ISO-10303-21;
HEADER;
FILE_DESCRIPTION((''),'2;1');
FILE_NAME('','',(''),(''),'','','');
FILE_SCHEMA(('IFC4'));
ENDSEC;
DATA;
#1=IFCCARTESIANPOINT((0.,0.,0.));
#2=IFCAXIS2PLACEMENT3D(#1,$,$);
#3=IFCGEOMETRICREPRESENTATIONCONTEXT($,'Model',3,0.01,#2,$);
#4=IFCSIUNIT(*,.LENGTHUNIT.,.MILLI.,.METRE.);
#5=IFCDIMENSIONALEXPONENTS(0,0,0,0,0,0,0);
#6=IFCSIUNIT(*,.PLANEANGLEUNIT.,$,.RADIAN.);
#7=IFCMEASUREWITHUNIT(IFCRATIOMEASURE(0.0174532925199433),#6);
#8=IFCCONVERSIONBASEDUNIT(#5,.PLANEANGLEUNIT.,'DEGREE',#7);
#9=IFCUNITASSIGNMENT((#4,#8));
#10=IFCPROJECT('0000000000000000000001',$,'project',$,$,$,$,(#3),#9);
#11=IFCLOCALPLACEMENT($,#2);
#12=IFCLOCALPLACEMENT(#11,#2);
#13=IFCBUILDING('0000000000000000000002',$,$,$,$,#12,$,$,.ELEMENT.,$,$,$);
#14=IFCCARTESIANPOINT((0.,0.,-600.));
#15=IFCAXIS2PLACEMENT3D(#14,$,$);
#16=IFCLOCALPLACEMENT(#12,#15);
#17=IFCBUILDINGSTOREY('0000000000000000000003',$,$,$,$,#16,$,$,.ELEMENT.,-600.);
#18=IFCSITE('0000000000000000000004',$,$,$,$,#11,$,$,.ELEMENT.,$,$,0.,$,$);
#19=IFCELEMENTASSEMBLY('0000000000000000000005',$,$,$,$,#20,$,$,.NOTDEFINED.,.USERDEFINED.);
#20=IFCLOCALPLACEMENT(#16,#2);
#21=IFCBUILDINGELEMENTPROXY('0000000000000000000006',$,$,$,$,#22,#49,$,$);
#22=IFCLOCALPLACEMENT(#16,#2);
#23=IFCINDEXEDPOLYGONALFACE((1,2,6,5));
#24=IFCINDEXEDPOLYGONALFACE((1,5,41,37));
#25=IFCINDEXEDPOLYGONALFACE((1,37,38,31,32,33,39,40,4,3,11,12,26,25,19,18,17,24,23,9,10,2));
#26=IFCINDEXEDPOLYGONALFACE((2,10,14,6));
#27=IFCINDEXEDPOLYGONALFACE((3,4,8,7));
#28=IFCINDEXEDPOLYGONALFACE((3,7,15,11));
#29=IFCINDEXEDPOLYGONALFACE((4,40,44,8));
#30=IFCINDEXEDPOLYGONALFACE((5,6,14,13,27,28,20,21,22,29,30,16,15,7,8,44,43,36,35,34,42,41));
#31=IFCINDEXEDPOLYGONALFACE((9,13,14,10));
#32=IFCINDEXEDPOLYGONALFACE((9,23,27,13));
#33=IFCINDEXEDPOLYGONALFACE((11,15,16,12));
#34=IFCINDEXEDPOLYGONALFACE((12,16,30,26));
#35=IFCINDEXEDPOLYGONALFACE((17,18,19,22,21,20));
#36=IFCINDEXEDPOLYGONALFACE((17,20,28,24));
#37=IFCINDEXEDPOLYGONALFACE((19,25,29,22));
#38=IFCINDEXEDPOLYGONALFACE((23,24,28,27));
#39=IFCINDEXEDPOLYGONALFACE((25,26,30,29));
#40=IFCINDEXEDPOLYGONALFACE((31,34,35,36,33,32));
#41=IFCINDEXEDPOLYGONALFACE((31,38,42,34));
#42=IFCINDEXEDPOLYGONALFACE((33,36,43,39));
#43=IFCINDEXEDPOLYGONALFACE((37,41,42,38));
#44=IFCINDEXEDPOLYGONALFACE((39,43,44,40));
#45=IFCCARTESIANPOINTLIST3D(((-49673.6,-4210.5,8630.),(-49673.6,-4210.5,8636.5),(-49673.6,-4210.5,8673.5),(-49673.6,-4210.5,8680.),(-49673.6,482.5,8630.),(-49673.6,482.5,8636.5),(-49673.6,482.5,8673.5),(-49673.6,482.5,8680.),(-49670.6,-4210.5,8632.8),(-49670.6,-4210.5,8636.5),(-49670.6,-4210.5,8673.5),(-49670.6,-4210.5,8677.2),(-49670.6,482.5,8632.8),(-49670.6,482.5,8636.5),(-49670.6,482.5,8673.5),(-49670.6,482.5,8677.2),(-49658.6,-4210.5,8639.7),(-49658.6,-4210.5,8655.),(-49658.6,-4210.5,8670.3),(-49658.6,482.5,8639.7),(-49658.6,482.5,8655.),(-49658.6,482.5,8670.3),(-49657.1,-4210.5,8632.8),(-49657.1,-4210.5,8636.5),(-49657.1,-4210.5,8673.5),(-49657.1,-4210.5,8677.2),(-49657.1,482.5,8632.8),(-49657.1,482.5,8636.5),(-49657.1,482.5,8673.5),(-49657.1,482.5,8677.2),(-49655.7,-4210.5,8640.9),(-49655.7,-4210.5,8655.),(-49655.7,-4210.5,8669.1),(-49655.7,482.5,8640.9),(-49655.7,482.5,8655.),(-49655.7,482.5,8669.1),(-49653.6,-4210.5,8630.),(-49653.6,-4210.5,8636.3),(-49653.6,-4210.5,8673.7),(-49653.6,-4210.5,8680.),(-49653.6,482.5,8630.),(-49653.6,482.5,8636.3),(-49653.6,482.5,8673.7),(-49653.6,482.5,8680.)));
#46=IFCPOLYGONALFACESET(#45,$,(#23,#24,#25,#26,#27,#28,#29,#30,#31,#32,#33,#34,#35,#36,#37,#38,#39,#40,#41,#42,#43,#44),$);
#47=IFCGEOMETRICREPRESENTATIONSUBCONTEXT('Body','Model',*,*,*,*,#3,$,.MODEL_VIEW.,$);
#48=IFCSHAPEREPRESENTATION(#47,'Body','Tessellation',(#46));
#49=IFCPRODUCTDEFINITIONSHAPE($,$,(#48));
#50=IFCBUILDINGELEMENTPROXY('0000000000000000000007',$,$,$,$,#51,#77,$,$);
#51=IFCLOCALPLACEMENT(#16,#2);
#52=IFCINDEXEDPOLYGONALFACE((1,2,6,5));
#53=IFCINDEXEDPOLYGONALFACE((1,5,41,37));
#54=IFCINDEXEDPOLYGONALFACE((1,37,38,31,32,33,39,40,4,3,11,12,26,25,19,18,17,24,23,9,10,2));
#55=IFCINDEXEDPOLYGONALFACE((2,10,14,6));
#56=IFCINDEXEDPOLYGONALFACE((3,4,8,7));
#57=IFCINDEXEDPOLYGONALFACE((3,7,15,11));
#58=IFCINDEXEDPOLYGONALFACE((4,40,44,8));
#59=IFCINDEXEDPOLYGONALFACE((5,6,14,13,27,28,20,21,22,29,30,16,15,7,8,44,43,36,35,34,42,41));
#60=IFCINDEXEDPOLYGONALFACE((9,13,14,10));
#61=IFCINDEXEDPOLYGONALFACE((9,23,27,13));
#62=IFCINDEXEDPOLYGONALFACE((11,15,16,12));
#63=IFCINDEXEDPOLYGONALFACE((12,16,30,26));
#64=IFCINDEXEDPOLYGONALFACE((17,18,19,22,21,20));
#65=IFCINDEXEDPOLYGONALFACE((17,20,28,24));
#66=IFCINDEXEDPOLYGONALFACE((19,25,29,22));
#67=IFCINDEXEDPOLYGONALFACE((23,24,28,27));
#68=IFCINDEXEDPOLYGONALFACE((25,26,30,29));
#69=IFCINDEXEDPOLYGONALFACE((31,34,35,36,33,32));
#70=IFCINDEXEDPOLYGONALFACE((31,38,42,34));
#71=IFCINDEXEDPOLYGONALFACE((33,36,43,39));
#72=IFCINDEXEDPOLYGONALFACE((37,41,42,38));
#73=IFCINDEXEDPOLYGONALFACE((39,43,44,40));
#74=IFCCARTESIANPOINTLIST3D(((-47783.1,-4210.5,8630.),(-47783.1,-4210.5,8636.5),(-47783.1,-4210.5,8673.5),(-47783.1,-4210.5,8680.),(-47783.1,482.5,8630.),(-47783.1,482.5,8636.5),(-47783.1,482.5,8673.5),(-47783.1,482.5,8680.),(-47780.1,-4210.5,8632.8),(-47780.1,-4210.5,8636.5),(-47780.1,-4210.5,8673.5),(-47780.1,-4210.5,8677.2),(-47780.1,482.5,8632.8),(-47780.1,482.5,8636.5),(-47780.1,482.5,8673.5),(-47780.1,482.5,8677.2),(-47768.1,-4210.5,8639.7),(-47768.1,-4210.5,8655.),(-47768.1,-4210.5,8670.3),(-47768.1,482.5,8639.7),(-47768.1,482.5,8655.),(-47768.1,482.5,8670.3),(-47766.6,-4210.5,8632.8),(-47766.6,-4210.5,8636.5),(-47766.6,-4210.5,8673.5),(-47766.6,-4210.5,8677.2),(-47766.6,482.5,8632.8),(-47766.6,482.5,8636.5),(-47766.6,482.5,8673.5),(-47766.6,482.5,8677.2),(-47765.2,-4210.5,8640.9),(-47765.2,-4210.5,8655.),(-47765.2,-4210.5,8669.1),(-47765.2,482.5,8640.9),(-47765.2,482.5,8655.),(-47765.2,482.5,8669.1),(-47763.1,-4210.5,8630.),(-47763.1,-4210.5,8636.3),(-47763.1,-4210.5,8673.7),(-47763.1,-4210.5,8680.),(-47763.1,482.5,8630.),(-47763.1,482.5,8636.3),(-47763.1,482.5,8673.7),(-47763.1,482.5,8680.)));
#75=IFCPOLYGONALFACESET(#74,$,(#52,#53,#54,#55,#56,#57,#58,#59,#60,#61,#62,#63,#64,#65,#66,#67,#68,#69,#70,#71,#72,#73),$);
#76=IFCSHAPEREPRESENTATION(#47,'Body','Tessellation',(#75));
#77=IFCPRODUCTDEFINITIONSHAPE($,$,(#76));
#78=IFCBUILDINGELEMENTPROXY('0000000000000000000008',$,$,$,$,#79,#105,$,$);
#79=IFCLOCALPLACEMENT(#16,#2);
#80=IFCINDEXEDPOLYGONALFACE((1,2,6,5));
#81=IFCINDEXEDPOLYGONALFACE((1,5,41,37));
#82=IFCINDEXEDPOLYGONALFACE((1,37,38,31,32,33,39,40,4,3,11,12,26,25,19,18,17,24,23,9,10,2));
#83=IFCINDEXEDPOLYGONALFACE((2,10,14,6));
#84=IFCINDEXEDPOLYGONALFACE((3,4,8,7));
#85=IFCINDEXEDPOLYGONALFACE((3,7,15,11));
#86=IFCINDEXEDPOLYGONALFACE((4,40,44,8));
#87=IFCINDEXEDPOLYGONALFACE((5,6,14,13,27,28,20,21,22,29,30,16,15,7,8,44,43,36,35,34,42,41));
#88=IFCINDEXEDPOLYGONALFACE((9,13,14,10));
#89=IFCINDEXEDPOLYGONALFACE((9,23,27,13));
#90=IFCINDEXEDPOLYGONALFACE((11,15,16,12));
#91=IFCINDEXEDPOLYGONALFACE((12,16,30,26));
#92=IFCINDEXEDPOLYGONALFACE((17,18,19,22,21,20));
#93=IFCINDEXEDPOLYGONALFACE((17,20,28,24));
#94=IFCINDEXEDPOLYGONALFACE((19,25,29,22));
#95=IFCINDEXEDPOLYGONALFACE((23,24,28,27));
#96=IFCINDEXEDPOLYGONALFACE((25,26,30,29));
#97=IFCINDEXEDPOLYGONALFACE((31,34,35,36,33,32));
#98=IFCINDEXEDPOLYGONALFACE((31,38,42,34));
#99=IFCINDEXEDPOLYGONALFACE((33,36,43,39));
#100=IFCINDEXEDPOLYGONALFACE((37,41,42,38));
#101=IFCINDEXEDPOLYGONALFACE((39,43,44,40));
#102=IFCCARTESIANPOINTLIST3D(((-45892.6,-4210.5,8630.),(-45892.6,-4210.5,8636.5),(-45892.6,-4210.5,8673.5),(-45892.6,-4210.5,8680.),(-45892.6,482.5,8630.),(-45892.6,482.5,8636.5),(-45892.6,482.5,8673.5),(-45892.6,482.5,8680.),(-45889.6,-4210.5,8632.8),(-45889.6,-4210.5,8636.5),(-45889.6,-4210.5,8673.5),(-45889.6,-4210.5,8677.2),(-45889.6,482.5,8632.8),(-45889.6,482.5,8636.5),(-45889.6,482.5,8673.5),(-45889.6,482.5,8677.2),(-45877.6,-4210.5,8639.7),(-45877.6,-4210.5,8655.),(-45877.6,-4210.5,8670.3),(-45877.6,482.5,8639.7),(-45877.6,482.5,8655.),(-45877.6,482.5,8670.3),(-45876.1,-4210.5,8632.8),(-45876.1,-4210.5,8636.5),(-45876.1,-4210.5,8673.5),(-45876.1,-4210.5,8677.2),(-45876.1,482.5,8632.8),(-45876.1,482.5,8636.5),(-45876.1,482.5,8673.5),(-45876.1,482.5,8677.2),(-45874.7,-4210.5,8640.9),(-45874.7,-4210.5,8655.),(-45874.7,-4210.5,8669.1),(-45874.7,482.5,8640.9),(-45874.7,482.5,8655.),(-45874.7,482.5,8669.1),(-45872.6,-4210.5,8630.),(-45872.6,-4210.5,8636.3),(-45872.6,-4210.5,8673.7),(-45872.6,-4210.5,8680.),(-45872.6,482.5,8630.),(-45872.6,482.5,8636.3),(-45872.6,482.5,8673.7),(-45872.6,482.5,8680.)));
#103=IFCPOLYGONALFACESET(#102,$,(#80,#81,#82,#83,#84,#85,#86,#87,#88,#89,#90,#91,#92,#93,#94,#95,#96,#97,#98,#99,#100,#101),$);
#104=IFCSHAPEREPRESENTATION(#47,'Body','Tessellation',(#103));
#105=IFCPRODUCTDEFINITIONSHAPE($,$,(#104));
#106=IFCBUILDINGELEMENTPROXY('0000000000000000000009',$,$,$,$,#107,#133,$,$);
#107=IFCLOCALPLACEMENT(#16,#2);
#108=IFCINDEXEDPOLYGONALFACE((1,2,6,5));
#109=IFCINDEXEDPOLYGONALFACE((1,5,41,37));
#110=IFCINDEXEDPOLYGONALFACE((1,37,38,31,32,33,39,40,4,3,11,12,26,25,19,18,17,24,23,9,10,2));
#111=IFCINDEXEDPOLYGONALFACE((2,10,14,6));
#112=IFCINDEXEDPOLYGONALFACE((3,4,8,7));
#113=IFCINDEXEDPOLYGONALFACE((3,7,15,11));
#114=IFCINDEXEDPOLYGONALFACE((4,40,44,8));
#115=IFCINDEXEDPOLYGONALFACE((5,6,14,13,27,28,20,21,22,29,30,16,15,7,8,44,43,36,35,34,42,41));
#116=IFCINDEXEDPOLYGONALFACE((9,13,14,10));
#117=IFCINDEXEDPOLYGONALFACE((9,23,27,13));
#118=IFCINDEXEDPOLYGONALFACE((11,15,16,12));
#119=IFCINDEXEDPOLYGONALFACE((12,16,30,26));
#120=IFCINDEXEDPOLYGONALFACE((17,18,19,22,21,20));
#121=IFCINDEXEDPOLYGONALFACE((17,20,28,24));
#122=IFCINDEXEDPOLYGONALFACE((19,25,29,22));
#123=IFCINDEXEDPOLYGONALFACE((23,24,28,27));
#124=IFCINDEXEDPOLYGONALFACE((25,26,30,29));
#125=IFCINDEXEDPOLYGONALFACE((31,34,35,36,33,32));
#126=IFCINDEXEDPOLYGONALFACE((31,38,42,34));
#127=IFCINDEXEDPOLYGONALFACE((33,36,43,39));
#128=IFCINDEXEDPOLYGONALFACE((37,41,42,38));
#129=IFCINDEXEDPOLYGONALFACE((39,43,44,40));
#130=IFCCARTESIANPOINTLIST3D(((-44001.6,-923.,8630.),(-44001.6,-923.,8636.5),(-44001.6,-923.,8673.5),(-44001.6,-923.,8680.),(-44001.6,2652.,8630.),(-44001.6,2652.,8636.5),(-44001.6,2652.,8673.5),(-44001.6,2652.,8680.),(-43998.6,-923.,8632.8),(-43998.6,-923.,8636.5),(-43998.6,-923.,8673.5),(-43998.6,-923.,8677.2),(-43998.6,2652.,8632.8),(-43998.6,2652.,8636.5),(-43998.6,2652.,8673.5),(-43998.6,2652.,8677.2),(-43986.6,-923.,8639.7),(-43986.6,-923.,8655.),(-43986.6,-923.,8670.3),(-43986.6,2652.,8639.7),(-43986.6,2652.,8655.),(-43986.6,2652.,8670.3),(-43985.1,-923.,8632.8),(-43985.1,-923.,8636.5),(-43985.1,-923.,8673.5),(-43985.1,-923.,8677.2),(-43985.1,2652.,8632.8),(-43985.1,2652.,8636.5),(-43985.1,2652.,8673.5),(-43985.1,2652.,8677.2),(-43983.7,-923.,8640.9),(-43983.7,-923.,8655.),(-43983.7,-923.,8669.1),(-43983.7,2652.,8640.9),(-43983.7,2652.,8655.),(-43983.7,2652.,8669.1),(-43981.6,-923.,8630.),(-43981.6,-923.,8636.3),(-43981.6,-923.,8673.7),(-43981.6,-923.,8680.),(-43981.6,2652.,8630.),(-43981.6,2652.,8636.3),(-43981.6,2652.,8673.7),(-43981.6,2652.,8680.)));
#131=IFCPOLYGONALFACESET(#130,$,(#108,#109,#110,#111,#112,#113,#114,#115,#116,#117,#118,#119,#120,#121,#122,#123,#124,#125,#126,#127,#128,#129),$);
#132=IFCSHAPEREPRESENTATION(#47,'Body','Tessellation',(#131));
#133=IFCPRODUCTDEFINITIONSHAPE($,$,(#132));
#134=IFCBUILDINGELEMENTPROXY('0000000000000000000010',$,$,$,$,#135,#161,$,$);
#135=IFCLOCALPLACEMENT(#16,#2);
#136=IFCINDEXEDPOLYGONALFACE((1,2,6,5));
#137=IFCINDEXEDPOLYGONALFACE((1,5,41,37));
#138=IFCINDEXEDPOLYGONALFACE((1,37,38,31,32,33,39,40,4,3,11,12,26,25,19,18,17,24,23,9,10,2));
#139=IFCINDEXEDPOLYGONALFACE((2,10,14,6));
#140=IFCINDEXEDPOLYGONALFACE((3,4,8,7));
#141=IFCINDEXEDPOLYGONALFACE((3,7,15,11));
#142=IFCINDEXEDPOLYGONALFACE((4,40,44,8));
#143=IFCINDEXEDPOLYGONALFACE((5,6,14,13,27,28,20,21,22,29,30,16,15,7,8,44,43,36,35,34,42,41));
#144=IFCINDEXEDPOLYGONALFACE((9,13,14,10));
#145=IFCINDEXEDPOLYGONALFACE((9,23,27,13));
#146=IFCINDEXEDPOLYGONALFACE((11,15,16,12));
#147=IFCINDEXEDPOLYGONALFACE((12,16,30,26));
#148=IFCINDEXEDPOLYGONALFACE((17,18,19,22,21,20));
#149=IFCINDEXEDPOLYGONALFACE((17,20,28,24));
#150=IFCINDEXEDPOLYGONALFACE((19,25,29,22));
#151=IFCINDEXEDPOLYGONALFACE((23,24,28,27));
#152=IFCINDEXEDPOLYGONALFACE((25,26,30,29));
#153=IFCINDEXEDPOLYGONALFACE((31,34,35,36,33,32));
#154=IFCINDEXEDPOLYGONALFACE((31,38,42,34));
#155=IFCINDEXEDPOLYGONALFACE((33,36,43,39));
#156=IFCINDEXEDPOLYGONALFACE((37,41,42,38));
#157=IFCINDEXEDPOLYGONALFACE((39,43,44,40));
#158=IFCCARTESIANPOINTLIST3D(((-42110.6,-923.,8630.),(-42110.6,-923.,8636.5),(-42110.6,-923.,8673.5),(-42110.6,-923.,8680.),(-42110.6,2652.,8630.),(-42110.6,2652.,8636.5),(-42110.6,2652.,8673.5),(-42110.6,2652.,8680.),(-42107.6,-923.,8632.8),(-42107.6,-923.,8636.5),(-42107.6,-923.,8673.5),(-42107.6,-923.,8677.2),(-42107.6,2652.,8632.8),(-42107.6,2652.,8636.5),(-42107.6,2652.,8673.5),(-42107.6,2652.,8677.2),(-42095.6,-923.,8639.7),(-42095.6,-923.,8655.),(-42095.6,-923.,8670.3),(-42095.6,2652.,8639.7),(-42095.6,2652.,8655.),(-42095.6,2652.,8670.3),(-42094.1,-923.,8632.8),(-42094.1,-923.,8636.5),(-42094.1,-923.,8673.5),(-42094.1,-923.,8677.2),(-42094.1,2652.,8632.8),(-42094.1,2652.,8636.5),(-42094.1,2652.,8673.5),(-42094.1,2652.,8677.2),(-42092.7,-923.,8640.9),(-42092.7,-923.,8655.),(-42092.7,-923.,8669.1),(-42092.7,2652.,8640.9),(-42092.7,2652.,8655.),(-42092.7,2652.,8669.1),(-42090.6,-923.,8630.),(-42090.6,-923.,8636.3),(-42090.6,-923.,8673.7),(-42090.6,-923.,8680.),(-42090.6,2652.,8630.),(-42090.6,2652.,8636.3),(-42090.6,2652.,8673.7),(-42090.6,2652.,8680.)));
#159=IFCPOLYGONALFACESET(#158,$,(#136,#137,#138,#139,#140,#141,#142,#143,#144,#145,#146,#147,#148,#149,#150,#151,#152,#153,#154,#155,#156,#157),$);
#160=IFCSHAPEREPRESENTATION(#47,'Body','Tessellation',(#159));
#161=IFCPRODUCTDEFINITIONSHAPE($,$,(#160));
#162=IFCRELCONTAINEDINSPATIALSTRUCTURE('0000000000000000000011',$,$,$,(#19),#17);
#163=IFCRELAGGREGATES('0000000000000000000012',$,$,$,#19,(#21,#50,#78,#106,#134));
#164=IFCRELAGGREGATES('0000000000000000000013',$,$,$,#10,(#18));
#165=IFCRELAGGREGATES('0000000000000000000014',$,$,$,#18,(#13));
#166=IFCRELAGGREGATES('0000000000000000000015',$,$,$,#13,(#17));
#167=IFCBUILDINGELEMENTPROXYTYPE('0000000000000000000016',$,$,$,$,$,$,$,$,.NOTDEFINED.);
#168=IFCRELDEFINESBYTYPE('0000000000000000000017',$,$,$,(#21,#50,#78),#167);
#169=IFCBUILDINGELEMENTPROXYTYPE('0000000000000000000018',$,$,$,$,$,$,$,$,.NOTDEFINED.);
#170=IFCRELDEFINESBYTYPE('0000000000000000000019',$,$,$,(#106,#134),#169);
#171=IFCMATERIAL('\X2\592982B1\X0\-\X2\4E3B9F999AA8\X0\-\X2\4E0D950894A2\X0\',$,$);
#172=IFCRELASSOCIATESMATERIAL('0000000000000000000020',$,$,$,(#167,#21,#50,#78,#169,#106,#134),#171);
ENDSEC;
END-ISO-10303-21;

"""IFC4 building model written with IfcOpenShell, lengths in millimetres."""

from ifc_helpers import new_model, entity, si_unit, converted_unit, frame, origin, place, context, subcontext, project, spatial, polyline, outline, extrude, source, transform, mapped, material, type_object, type_shapes, element, aggregate, save


model = new_model("IFC4")

# Units and contexts
model_context = context("Model", 3, precision=0.01, world=origin())
body_context = subcontext(model_context, "Body", "Model", "MODEL_VIEW")
ifc_project = project(units=[si_unit("LENGTHUNIT", "METRE", prefix="MILLI"), converted_unit("PLANEANGLEUNIT", "DEGREE", entity("IfcRatioMeasure", 0.0174532925199433), si_unit("PLANEANGLEUNIT", "RADIAN"), dimensions=[0, 0, 0, 0, 0, 0, 0])], contexts=[model_context])

# Site, building, storey
site_placement = place(None, origin())
site = spatial("IfcSite", under=ifc_project, at=site_placement, CompositionType="ELEMENT", RefElevation=0.0)
building_placement = place(site_placement, origin())
building = spatial("IfcBuilding", under=site, at=building_placement, CompositionType="ELEMENT")
storey_placement = place(building_placement, frame((0.0, 0.0, -600.0)))
storey = spatial("IfcBuildingStorey", under=building, at=storey_placement, CompositionType="ELEMENT", Elevation=-600.0)

# Element assembly, building element proxies
assembly_1_placement = place(storey_placement, origin())
assembly_1 = element("IfcElementAssembly", 1, at=assembly_1_placement, inside=storey, AssemblyPlace="NOTDEFINED", PredefinedType="USERDEFINED")
ifc_material_1 = material(Name="天花-主龙骨-不锈钢")
building_element_proxy_type_1 = type_object("IfcBuildingElementProxyType", PredefinedType="NOTDEFINED", material=ifc_material_1)
shared_shape_1 = source(origin(), body_context, "Body", "SweptSolid", [
    extrude(outline(polyline([(-25.0, -11.7), (-18.5, -11.7), (-18.5, -8.7), (-22.2, -8.7), (-22.2, 4.8), (-18.5, 4.8), (-15.3, 3.3), (0.0, 3.3), (15.3, 3.3), (18.5, 4.8), (22.2, 4.8), (22.2, -8.7), (18.5, -8.7), (18.5, -11.7), (25.0, -11.7), (25.0, 8.3), (18.7, 8.3), (14.1, 6.2), (0.0, 6.2), (-14.1, 6.2), (-18.7, 8.3), (-25.0, 8.3), (-25.0, -11.7)])), frame((0.0, 1.7, 0.0), z_axis=(1.0, 0.0, 0.0), x_axis=(0.0, 0.0, -1.0)), (0.0, 0.0, 1.0), 4693.0),
])
type_shapes(building_element_proxy_type_1, [shared_shape_1])
proxy_1_placement = place(assembly_1_placement, frame((-49663.6, 482.5, 8655.0), z_axis=(0.0, 0.0, 1.0), x_axis=(0.0, -1.0, 0.0)))
proxy_1 = element("IfcBuildingElementProxy", 2, at=proxy_1_placement, type_object=building_element_proxy_type_1, material=ifc_material_1, context=body_context, shape_type="MappedRepresentation", body=[
    mapped(shared_shape_1, transform((0.0, 0.0, 0.0), scale=1.0)),
])
proxy_2_placement = place(assembly_1_placement, frame((-47773.1, 482.5, 8655.0), z_axis=(0.0, 0.0, 1.0), x_axis=(0.0, -1.0, 0.0)))
proxy_2 = element("IfcBuildingElementProxy", 3, at=proxy_2_placement, type_object=building_element_proxy_type_1, material=ifc_material_1, context=body_context, shape_type="MappedRepresentation", body=[
    mapped(shared_shape_1, transform((0.0, 0.0, 0.0), scale=1.0)),
])
proxy_3_placement = place(assembly_1_placement, frame((-45882.6, 482.5, 8655.0), z_axis=(0.0, 0.0, 1.0), x_axis=(0.0, -1.0, 0.0)))
proxy_3 = element("IfcBuildingElementProxy", 4, at=proxy_3_placement, type_object=building_element_proxy_type_1, material=ifc_material_1, context=body_context, shape_type="MappedRepresentation", body=[
    mapped(shared_shape_1, transform((0.0, 0.0, 0.0), scale=1.0)),
])
building_element_proxy_type_2 = type_object("IfcBuildingElementProxyType", PredefinedType="NOTDEFINED", material=ifc_material_1)
shared_shape_2 = source(origin(), body_context, "Body", "SweptSolid", [
    extrude(outline(polyline([(-25.0, -11.7), (-18.5, -11.7), (-18.5, -8.7), (-22.2, -8.7), (-22.2, 4.8), (-18.5, 4.8), (-15.3, 3.3), (0.0, 3.3), (15.3, 3.3), (18.5, 4.8), (22.2, 4.8), (22.2, -8.7), (18.5, -8.7), (18.5, -11.7), (25.0, -11.7), (25.0, 8.3), (18.7, 8.3), (14.1, 6.2), (0.0, 6.2), (-14.1, 6.2), (-18.7, 8.3), (-25.0, 8.3), (-25.0, -11.7)])), frame((0.0, 1.7, 0.0), z_axis=(1.0, 0.0, 0.0), x_axis=(0.0, 0.0, -1.0)), (0.0, 0.0, 1.0), 3575.0),
])
type_shapes(building_element_proxy_type_2, [shared_shape_2])
proxy_4_placement = place(assembly_1_placement, frame((-43991.6, 2652.0, 8655.0), z_axis=(0.0, 0.0, 1.0), x_axis=(0.0, -1.0, 0.0)))
proxy_4 = element("IfcBuildingElementProxy", 5, at=proxy_4_placement, type_object=building_element_proxy_type_2, material=ifc_material_1, context=body_context, shape_type="MappedRepresentation", body=[
    mapped(shared_shape_2, transform((0.0, 0.0, 0.0), scale=1.0)),
])
proxy_5_placement = place(assembly_1_placement, frame((-42100.6, 2652.0, 8655.0), z_axis=(0.0, 0.0, 1.0), x_axis=(0.0, -1.0, 0.0)))
proxy_5 = element("IfcBuildingElementProxy", 6, at=proxy_5_placement, type_object=building_element_proxy_type_2, material=ifc_material_1, context=body_context, shape_type="MappedRepresentation", body=[
    mapped(shared_shape_2, transform((0.0, 0.0, 0.0), scale=1.0)),
])
aggregate(assembly_1, [proxy_1, proxy_2, proxy_3, proxy_4, proxy_5])

save(model, "model.ifc")
